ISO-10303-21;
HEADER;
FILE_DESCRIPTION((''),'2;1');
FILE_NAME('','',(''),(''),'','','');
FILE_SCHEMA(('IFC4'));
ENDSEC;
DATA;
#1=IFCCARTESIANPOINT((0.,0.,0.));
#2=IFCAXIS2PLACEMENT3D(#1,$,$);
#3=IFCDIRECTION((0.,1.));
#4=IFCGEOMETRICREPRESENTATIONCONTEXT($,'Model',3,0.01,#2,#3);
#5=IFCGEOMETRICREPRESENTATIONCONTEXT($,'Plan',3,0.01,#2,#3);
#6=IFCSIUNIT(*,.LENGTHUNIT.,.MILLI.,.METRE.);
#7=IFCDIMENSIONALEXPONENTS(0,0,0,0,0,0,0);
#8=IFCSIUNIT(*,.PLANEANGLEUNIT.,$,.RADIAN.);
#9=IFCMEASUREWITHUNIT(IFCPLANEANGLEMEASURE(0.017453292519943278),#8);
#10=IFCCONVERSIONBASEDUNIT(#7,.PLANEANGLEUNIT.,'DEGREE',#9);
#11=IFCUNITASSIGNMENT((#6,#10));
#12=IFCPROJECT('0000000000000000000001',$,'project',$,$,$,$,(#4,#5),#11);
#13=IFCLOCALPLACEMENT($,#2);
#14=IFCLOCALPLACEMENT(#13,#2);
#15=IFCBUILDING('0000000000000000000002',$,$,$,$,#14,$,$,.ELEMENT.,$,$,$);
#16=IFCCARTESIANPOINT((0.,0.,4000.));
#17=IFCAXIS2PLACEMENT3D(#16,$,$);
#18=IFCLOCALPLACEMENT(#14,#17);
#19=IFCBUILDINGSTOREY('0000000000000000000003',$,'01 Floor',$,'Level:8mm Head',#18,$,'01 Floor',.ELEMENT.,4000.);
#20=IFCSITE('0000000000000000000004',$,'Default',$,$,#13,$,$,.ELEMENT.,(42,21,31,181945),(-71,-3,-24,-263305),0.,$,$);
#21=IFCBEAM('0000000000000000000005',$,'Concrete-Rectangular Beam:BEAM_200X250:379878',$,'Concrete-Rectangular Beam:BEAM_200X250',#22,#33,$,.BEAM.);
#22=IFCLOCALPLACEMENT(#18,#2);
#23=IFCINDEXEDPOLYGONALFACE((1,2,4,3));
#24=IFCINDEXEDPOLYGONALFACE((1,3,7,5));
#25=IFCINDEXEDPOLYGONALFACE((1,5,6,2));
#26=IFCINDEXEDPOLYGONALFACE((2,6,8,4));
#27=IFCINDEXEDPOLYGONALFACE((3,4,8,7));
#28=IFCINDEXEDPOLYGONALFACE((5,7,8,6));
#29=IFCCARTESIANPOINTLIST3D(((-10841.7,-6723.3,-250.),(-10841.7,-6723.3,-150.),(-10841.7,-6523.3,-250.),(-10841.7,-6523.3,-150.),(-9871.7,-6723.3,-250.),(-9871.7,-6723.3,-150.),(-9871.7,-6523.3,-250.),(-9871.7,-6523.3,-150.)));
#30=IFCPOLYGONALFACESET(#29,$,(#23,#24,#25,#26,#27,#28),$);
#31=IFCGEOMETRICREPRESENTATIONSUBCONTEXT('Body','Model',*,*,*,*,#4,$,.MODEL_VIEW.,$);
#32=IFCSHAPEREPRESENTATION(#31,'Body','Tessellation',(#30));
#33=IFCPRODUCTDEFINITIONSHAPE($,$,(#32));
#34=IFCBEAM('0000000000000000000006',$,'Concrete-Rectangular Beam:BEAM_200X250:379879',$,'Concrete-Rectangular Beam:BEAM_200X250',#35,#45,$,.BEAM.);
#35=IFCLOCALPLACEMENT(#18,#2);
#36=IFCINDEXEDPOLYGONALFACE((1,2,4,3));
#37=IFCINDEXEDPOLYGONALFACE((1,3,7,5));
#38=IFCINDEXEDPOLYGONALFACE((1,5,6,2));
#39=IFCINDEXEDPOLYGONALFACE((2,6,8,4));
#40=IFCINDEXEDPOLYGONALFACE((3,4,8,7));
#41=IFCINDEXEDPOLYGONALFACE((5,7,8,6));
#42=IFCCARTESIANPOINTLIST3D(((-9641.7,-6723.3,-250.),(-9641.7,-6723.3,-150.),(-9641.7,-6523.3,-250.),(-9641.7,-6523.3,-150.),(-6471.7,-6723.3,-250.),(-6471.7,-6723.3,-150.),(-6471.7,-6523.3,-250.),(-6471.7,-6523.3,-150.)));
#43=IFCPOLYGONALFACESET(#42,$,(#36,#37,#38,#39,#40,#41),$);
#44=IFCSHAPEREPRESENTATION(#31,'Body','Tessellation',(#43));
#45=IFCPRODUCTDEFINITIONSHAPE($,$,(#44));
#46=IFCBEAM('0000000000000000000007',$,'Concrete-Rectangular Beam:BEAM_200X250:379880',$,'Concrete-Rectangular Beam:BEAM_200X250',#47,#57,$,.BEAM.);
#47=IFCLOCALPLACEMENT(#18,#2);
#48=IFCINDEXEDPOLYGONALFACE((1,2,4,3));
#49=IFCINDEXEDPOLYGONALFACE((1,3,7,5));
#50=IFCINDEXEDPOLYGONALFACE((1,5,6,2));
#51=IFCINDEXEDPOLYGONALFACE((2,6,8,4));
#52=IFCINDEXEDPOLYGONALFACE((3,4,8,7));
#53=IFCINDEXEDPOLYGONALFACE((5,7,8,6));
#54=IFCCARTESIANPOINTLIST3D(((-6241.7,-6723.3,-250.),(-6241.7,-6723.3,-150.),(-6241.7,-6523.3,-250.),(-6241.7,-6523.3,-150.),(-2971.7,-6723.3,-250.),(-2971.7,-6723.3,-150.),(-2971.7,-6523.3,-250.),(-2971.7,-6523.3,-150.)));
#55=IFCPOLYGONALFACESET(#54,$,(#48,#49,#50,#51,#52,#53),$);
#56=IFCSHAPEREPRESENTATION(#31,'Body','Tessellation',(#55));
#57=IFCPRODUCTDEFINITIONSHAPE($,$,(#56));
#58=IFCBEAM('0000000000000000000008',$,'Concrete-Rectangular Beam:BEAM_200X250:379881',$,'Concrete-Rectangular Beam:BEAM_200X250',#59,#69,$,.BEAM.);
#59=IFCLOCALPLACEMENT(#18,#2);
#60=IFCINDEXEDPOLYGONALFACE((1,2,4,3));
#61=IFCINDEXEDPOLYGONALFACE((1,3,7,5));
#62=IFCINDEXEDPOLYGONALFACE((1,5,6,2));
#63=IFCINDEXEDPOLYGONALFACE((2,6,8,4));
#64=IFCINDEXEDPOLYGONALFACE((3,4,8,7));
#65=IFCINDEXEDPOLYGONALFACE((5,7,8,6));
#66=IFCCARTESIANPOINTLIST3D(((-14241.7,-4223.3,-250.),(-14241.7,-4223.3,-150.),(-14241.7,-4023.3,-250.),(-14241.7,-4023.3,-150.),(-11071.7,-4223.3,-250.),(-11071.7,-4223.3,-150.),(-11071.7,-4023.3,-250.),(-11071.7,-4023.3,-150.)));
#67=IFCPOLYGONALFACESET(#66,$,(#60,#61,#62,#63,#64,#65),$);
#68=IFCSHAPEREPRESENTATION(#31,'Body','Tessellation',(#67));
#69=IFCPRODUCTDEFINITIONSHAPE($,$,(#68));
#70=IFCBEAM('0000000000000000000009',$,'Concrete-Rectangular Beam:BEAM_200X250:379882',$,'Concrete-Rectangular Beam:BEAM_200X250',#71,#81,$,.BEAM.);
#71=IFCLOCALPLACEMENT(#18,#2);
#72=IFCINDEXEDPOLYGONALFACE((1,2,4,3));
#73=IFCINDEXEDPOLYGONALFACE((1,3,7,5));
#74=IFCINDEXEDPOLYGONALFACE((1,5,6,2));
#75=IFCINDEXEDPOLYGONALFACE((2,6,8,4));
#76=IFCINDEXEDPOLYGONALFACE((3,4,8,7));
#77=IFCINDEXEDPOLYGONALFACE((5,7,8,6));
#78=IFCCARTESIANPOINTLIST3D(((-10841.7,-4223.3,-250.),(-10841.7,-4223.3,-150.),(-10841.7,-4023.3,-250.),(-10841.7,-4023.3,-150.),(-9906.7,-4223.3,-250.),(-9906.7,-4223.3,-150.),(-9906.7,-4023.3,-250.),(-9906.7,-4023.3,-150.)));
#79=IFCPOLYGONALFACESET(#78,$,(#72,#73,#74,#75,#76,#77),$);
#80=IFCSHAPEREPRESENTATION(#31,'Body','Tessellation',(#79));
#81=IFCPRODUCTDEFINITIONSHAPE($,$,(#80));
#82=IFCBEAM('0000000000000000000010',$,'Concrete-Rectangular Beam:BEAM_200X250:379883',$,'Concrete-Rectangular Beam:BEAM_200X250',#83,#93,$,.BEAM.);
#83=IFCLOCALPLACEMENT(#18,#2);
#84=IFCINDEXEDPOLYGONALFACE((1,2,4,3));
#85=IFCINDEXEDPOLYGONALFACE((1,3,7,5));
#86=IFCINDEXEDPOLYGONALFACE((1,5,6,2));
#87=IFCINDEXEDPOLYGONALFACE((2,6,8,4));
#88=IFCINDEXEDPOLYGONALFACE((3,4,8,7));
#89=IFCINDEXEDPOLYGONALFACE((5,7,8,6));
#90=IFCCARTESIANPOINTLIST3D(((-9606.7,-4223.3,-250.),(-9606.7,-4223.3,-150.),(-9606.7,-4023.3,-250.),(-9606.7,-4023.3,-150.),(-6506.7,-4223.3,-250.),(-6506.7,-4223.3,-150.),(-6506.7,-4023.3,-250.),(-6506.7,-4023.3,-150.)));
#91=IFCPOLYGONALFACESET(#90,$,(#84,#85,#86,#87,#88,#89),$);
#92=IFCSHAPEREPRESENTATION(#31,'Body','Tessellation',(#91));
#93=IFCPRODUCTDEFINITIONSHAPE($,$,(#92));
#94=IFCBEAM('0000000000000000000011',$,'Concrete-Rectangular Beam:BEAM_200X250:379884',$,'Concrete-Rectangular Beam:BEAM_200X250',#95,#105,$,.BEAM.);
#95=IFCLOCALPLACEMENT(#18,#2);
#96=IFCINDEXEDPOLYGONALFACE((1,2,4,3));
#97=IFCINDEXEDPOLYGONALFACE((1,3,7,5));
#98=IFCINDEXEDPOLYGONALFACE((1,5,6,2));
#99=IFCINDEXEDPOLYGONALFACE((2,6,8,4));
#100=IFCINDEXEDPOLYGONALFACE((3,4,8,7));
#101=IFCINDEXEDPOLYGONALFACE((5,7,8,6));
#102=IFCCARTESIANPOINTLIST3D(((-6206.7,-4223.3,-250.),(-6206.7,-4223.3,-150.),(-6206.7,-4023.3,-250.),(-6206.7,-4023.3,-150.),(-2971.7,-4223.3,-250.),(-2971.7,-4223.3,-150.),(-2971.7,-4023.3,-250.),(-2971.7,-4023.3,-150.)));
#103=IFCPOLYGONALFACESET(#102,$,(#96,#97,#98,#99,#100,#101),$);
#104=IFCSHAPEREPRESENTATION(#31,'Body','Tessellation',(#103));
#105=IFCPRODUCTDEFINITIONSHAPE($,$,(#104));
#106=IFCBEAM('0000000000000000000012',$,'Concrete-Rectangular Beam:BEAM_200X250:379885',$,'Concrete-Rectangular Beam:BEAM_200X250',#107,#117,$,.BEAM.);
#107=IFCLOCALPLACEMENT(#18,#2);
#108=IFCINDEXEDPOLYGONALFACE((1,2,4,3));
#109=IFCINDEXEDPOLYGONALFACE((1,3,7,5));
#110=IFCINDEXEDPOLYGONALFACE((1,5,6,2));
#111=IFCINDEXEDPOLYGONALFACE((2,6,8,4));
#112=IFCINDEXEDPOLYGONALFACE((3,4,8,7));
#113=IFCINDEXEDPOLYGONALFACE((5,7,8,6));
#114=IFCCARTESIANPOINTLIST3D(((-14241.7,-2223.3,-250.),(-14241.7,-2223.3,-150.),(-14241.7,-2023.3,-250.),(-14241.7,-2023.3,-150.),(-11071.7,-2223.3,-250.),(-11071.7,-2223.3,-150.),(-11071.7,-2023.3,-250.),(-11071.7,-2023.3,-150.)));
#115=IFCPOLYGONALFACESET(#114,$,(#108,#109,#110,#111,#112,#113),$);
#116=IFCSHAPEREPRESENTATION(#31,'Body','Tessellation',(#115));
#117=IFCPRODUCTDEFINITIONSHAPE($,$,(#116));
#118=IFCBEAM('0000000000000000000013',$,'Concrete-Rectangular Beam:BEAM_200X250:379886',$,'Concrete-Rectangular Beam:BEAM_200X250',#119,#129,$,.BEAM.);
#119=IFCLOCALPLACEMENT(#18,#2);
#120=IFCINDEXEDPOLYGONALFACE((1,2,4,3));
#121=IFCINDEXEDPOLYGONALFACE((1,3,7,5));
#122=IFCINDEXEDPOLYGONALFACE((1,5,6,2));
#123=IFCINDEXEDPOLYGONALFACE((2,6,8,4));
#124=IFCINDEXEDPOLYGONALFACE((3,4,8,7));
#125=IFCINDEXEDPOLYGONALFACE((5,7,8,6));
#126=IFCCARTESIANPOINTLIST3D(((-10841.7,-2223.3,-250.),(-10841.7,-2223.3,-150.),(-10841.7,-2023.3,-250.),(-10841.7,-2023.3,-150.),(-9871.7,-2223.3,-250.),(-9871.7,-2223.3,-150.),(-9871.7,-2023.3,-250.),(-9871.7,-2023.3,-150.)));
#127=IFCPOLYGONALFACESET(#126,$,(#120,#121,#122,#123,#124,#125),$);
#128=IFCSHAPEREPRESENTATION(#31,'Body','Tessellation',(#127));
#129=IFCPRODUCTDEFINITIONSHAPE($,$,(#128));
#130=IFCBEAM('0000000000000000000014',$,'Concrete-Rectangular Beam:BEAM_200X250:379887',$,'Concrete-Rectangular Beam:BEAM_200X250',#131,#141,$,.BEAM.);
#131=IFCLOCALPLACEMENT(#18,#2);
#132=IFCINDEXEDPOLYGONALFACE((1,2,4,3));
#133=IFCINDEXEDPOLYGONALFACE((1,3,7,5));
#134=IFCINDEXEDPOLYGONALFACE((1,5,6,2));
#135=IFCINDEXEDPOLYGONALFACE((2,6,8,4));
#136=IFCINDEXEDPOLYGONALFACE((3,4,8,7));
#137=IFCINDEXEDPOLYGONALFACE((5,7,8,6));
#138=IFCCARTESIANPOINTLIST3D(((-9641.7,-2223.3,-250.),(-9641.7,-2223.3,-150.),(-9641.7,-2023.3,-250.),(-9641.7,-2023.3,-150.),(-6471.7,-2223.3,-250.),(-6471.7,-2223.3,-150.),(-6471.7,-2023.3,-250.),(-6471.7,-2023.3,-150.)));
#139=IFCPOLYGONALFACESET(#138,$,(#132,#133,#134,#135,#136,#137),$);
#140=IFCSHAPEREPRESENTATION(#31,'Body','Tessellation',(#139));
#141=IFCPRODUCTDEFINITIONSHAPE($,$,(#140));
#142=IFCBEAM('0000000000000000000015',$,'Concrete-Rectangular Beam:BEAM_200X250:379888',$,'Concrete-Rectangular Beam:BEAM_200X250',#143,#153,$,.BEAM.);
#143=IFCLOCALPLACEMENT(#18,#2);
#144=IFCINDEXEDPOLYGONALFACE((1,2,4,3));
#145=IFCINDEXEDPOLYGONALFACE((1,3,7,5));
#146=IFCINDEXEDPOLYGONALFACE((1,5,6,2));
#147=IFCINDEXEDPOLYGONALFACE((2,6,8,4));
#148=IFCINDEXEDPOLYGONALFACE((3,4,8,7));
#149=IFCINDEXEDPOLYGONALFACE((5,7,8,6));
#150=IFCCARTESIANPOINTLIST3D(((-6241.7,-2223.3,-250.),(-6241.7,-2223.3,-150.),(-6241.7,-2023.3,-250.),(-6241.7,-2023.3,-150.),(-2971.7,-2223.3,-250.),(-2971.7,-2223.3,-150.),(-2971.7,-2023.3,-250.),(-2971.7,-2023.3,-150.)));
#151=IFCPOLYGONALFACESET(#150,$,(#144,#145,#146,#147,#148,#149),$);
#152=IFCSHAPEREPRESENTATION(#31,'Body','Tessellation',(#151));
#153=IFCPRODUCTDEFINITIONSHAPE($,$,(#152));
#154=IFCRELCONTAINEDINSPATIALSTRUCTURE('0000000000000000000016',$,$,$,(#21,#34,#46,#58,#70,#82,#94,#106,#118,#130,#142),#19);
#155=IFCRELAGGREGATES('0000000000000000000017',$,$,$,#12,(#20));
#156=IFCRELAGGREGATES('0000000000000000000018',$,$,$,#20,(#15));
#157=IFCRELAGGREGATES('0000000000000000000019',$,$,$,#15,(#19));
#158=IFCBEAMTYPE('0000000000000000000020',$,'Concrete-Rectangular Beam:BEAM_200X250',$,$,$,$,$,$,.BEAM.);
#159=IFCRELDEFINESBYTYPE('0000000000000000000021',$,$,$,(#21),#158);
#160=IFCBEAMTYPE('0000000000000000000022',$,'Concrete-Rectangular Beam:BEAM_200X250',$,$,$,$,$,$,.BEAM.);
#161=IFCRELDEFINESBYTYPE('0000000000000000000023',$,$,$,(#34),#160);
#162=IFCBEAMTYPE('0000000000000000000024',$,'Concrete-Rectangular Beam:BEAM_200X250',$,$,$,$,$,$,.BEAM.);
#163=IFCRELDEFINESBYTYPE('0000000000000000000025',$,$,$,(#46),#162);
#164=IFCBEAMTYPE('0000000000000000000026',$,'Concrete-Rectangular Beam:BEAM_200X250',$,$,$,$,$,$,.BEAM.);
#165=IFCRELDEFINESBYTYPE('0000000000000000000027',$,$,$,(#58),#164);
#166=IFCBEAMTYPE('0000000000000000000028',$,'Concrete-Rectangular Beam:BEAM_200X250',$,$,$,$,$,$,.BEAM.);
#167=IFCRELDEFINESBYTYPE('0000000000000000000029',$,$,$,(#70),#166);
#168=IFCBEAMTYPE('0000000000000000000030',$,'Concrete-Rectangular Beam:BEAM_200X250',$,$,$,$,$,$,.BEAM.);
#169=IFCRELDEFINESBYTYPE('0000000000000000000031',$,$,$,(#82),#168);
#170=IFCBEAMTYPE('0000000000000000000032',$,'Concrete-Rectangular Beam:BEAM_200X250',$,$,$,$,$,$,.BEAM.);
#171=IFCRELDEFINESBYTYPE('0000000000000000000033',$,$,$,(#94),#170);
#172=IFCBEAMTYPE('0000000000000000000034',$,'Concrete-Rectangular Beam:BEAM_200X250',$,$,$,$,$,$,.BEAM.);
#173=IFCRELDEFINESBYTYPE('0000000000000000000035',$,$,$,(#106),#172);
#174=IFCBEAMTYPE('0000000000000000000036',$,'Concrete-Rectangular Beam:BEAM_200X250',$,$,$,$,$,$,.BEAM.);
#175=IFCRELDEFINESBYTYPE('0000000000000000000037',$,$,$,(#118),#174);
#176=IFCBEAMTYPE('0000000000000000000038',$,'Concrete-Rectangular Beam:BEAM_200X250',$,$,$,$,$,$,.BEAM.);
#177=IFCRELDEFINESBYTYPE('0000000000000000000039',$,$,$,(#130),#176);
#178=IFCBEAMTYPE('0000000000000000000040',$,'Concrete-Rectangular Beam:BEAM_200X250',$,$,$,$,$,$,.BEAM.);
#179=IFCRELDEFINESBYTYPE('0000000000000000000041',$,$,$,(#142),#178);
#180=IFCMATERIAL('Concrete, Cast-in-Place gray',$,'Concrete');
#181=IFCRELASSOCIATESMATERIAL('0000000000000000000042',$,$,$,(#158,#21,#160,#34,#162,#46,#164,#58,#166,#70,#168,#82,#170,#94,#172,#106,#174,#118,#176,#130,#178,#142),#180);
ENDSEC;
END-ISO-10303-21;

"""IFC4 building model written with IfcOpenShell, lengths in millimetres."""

from ifc_helpers import new_model, entity, si_unit, converted_unit, direction, frame, origin, place, context, subcontext, project, spatial, indexed_curve, outline, extrude, source, transform, mapped, material, type_object, type_shapes, element, save


model = new_model("IFC4")

# Units and contexts
model_context = context("Model", 3, precision=0.01, world=origin(), true_north=direction((0.0, 1.0)))
plan_context = context("Plan", 3, precision=0.01, world=origin(), true_north=direction((0.0, 1.0)))
body_context = subcontext(model_context, "Body", "Model", "MODEL_VIEW")
ifc_project = project(units=[si_unit("LENGTHUNIT", "METRE", prefix="MILLI"), converted_unit("PLANEANGLEUNIT", "DEGREE", entity("IfcPlaneAngleMeasure", 0.017453292519943278), si_unit("PLANEANGLEUNIT", "RADIAN"), dimensions=[0, 0, 0, 0, 0, 0, 0])], contexts=[model_context, plan_context])

# Site, building, storey
site_placement = place(None, origin())
site = spatial("IfcSite", under=ifc_project, at=site_placement, Name="Default", CompositionType="ELEMENT", RefLatitude=(42, 21, 31, 181945), RefLongitude=(-71, -3, -24, -263305), RefElevation=0.0)
building_placement = place(site_placement, origin())
building = spatial("IfcBuilding", under=site, at=building_placement, CompositionType="ELEMENT")
storey_placement = place(building_placement, frame((0.0, 0.0, 4000.0)))
storey = spatial("IfcBuildingStorey", under=building, at=storey_placement, Name="01 Floor", ObjectType="Level:8mm Head", LongName="01 Floor", CompositionType="ELEMENT", Elevation=4000.0)

# Beams
ifc_material = material(Name="Concrete, Cast-in-Place gray", Category="Concrete")
beam_type_1 = type_object("IfcBeamType", Name="Concrete-Rectangular Beam:BEAM_200X250", PredefinedType="BEAM", material=ifc_material)
shared_shape_1 = source(origin(), body_context, "Body", "SweptSolid", [
    extrude(outline(indexed_curve([(-50.0, -100.0), (50.0, -100.0), (50.0, 100.0), (-50.0, 100.0), (-50.0, -100.0)], self_intersect=False)), frame((-10841.7, -6623.3, 3800.0), z_axis=(1.0, 0.0, 0.0), x_axis=(0.0, 0.0, -1.0)), (0.0, 0.0, 1.0), 970.0),
])
type_shapes(beam_type_1, [shared_shape_1])
beam_1_placement = place(storey_placement, frame((0.0, 0.0, -4000.0)))
element("IfcBeam", 1, at=beam_1_placement, inside=storey, type_object=beam_type_1, material=ifc_material, Name="Concrete-Rectangular Beam:BEAM_200X250:379878", ObjectType="Concrete-Rectangular Beam:BEAM_200X250", PredefinedType="BEAM", context=body_context, shape_type="MappedRepresentation", body=[
    mapped(shared_shape_1, transform((0.0, 0.0, 0.0), scale=1.0)),
])
beam_type_2 = type_object("IfcBeamType", Name="Concrete-Rectangular Beam:BEAM_200X250", PredefinedType="BEAM", material=ifc_material)
shared_shape_2 = source(origin(), body_context, "Body", "SweptSolid", [
    extrude(outline(indexed_curve([(-50.0, -100.0), (50.0, -100.0), (50.0, 100.0), (-50.0, 100.0), (-50.0, -100.0)], self_intersect=False)), frame((-9641.7, -6623.3, 3800.0), z_axis=(1.0, 0.0, 0.0), x_axis=(0.0, 0.0, -1.0)), (0.0, 0.0, 1.0), 3170.0),
])
type_shapes(beam_type_2, [shared_shape_2])
beam_2_placement = place(storey_placement, frame((0.0, 0.0, -4000.0)))
element("IfcBeam", 2, at=beam_2_placement, inside=storey, type_object=beam_type_2, material=ifc_material, Name="Concrete-Rectangular Beam:BEAM_200X250:379879", ObjectType="Concrete-Rectangular Beam:BEAM_200X250", PredefinedType="BEAM", context=body_context, shape_type="MappedRepresentation", body=[
    mapped(shared_shape_2, transform((0.0, 0.0, 0.0), scale=1.0)),
])
beam_type_3 = type_object("IfcBeamType", Name="Concrete-Rectangular Beam:BEAM_200X250", PredefinedType="BEAM", material=ifc_material)
shared_shape_3 = source(origin(), body_context, "Body", "SweptSolid", [
    extrude(outline(indexed_curve([(-50.0, -100.0), (50.0, -100.0), (50.0, 100.0), (-50.0, 100.0), (-50.0, -100.0)], self_intersect=False)), frame((-6241.7, -6623.3, 3800.0), z_axis=(1.0, 0.0, 0.0), x_axis=(0.0, 0.0, -1.0)), (0.0, 0.0, 1.0), 3270.0),
])
type_shapes(beam_type_3, [shared_shape_3])
beam_3_placement = place(storey_placement, frame((0.0, 0.0, -4000.0)))
element("IfcBeam", 3, at=beam_3_placement, inside=storey, type_object=beam_type_3, material=ifc_material, Name="Concrete-Rectangular Beam:BEAM_200X250:379880", ObjectType="Concrete-Rectangular Beam:BEAM_200X250", PredefinedType="BEAM", context=body_context, shape_type="MappedRepresentation", body=[
    mapped(shared_shape_3, transform((0.0, 0.0, 0.0), scale=1.0)),
])
beam_type_4 = type_object("IfcBeamType", Name="Concrete-Rectangular Beam:BEAM_200X250", PredefinedType="BEAM", material=ifc_material)
shared_shape_4 = source(origin(), body_context, "Body", "SweptSolid", [
    extrude(outline(indexed_curve([(-50.0, -100.0), (50.0, -100.0), (50.0, 100.0), (-50.0, 100.0), (-50.0, -100.0)], self_intersect=False)), frame((-14241.7, -4123.3, 3800.0), z_axis=(1.0, 0.0, 0.0), x_axis=(0.0, 0.0, -1.0)), (0.0, 0.0, 1.0), 3170.0),
])
type_shapes(beam_type_4, [shared_shape_4])
beam_4_placement = place(storey_placement, frame((0.0, 0.0, -4000.0)))
element("IfcBeam", 4, at=beam_4_placement, inside=storey, type_object=beam_type_4, material=ifc_material, Name="Concrete-Rectangular Beam:BEAM_200X250:379881", ObjectType="Concrete-Rectangular Beam:BEAM_200X250", PredefinedType="BEAM", context=body_context, shape_type="MappedRepresentation", body=[
    mapped(shared_shape_4, transform((0.0, 0.0, 0.0), scale=1.0)),
])
beam_type_5 = type_object("IfcBeamType", Name="Concrete-Rectangular Beam:BEAM_200X250", PredefinedType="BEAM", material=ifc_material)
shared_shape_5 = source(origin(), body_context, "Body", "SweptSolid", [
    extrude(outline(indexed_curve([(-50.0, -100.0), (50.0, -100.0), (50.0, 100.0), (-50.0, 100.0), (-50.0, -100.0)], self_intersect=False)), frame((-10841.7, -4123.3, 3800.0), z_axis=(1.0, 0.0, 0.0), x_axis=(0.0, 0.0, -1.0)), (0.0, 0.0, 1.0), 935.0),
])
type_shapes(beam_type_5, [shared_shape_5])
beam_5_placement = place(storey_placement, frame((0.0, 0.0, -4000.0)))
element("IfcBeam", 5, at=beam_5_placement, inside=storey, type_object=beam_type_5, material=ifc_material, Name="Concrete-Rectangular Beam:BEAM_200X250:379882", ObjectType="Concrete-Rectangular Beam:BEAM_200X250", PredefinedType="BEAM", context=body_context, shape_type="MappedRepresentation", body=[
    mapped(shared_shape_5, transform((0.0, 0.0, 0.0), scale=1.0)),
])
beam_type_6 = type_object("IfcBeamType", Name="Concrete-Rectangular Beam:BEAM_200X250", PredefinedType="BEAM", material=ifc_material)
shared_shape_6 = source(origin(), body_context, "Body", "SweptSolid", [
    extrude(outline(indexed_curve([(-50.0, -100.0), (50.0, -100.0), (50.0, 100.0), (-50.0, 100.0), (-50.0, -100.0)], self_intersect=False)), frame((-9606.7, -4123.3, 3800.0), z_axis=(1.0, 0.0, 0.0), x_axis=(0.0, 0.0, -1.0)), (0.0, 0.0, 1.0), 3100.0),
])
type_shapes(beam_type_6, [shared_shape_6])
beam_6_placement = place(storey_placement, frame((0.0, 0.0, -4000.0)))
element("IfcBeam", 6, at=beam_6_placement, inside=storey, type_object=beam_type_6, material=ifc_material, Name="Concrete-Rectangular Beam:BEAM_200X250:379883", ObjectType="Concrete-Rectangular Beam:BEAM_200X250", PredefinedType="BEAM", context=body_context, shape_type="MappedRepresentation", body=[
    mapped(shared_shape_6, transform((0.0, 0.0, 0.0), scale=1.0)),
])
beam_type_7 = type_object("IfcBeamType", Name="Concrete-Rectangular Beam:BEAM_200X250", PredefinedType="BEAM", material=ifc_material)
shared_shape_7 = source(origin(), body_context, "Body", "SweptSolid", [
    extrude(outline(indexed_curve([(-50.0, -100.0), (50.0, -100.0), (50.0, 100.0), (-50.0, 100.0), (-50.0, -100.0)], self_intersect=False)), frame((-6206.7, -4123.3, 3800.0), z_axis=(1.0, 0.0, 0.0), x_axis=(0.0, 0.0, -1.0)), (0.0, 0.0, 1.0), 3235.0),
])
type_shapes(beam_type_7, [shared_shape_7])
beam_7_placement = place(storey_placement, frame((0.0, 0.0, -4000.0)))
element("IfcBeam", 7, at=beam_7_placement, inside=storey, type_object=beam_type_7, material=ifc_material, Name="Concrete-Rectangular Beam:BEAM_200X250:379884", ObjectType="Concrete-Rectangular Beam:BEAM_200X250", PredefinedType="BEAM", context=body_context, shape_type="MappedRepresentation", body=[
    mapped(shared_shape_7, transform((0.0, 0.0, 0.0), scale=1.0)),
])
beam_type_8 = type_object("IfcBeamType", Name="Concrete-Rectangular Beam:BEAM_200X250", PredefinedType="BEAM", material=ifc_material)
shared_shape_8 = source(origin(), body_context, "Body", "SweptSolid", [
    extrude(outline(indexed_curve([(-50.0, -100.0), (50.0, -100.0), (50.0, 100.0), (-50.0, 100.0), (-50.0, -100.0)], self_intersect=False)), frame((-14241.7, -2123.3, 3800.0), z_axis=(1.0, 0.0, 0.0), x_axis=(0.0, 0.0, -1.0)), (0.0, 0.0, 1.0), 3170.0),
])
type_shapes(beam_type_8, [shared_shape_8])
beam_8_placement = place(storey_placement, frame((0.0, 0.0, -4000.0)))
element("IfcBeam", 8, at=beam_8_placement, inside=storey, type_object=beam_type_8, material=ifc_material, Name="Concrete-Rectangular Beam:BEAM_200X250:379885", ObjectType="Concrete-Rectangular Beam:BEAM_200X250", PredefinedType="BEAM", context=body_context, shape_type="MappedRepresentation", body=[
    mapped(shared_shape_8, transform((0.0, 0.0, 0.0), scale=1.0)),
])
beam_type_9 = type_object("IfcBeamType", Name="Concrete-Rectangular Beam:BEAM_200X250", PredefinedType="BEAM", material=ifc_material)
shared_shape_9 = source(origin(), body_context, "Body", "SweptSolid", [
    extrude(outline(indexed_curve([(-50.0, -100.0), (50.0, -100.0), (50.0, 100.0), (-50.0, 100.0), (-50.0, -100.0)], self_intersect=False)), frame((-10841.7, -2123.3, 3800.0), z_axis=(1.0, 0.0, 0.0), x_axis=(0.0, 0.0, -1.0)), (0.0, 0.0, 1.0), 970.0),
])
type_shapes(beam_type_9, [shared_shape_9])
beam_9_placement = place(storey_placement, frame((0.0, 0.0, -4000.0)))
element("IfcBeam", 9, at=beam_9_placement, inside=storey, type_object=beam_type_9, material=ifc_material, Name="Concrete-Rectangular Beam:BEAM_200X250:379886", ObjectType="Concrete-Rectangular Beam:BEAM_200X250", PredefinedType="BEAM", context=body_context, shape_type="MappedRepresentation", body=[
    mapped(shared_shape_9, transform((0.0, 0.0, 0.0), scale=1.0)),
])
beam_type_10 = type_object("IfcBeamType", Name="Concrete-Rectangular Beam:BEAM_200X250", PredefinedType="BEAM", material=ifc_material)
shared_shape_10 = source(origin(), body_context, "Body", "SweptSolid", [
    extrude(outline(indexed_curve([(-50.0, -100.0), (50.0, -100.0), (50.0, 100.0), (-50.0, 100.0), (-50.0, -100.0)], self_intersect=False)), frame((-9641.7, -2123.3, 3800.0), z_axis=(1.0, 0.0, 0.0), x_axis=(0.0, 0.0, -1.0)), (0.0, 0.0, 1.0), 3170.0),
])
type_shapes(beam_type_10, [shared_shape_10])
beam_10_placement = place(storey_placement, frame((0.0, 0.0, -4000.0)))
element("IfcBeam", 10, at=beam_10_placement, inside=storey, type_object=beam_type_10, material=ifc_material, Name="Concrete-Rectangular Beam:BEAM_200X250:379887", ObjectType="Concrete-Rectangular Beam:BEAM_200X250", PredefinedType="BEAM", context=body_context, shape_type="MappedRepresentation", body=[
    mapped(shared_shape_10, transform((0.0, 0.0, 0.0), scale=1.0)),
])
beam_type_11 = type_object("IfcBeamType", Name="Concrete-Rectangular Beam:BEAM_200X250", PredefinedType="BEAM", material=ifc_material)
shared_shape_11 = source(origin(), body_context, "Body", "SweptSolid", [
    extrude(outline(indexed_curve([(-50.0, -100.0), (50.0, -100.0), (50.0, 100.0), (-50.0, 100.0), (-50.0, -100.0)], self_intersect=False)), frame((-6241.7, -2123.3, 3800.0), z_axis=(1.0, 0.0, 0.0), x_axis=(0.0, 0.0, -1.0)), (0.0, 0.0, 1.0), 3270.0),
])
type_shapes(beam_type_11, [shared_shape_11])
beam_11_placement = place(storey_placement, frame((0.0, 0.0, -4000.0)))
element("IfcBeam", 11, at=beam_11_placement, inside=storey, type_object=beam_type_11, material=ifc_material, Name="Concrete-Rectangular Beam:BEAM_200X250:379888", ObjectType="Concrete-Rectangular Beam:BEAM_200X250", PredefinedType="BEAM", context=body_context, shape_type="MappedRepresentation", body=[
    mapped(shared_shape_11, transform((0.0, 0.0, 0.0), scale=1.0)),
])

save(model, "model.ifc")
